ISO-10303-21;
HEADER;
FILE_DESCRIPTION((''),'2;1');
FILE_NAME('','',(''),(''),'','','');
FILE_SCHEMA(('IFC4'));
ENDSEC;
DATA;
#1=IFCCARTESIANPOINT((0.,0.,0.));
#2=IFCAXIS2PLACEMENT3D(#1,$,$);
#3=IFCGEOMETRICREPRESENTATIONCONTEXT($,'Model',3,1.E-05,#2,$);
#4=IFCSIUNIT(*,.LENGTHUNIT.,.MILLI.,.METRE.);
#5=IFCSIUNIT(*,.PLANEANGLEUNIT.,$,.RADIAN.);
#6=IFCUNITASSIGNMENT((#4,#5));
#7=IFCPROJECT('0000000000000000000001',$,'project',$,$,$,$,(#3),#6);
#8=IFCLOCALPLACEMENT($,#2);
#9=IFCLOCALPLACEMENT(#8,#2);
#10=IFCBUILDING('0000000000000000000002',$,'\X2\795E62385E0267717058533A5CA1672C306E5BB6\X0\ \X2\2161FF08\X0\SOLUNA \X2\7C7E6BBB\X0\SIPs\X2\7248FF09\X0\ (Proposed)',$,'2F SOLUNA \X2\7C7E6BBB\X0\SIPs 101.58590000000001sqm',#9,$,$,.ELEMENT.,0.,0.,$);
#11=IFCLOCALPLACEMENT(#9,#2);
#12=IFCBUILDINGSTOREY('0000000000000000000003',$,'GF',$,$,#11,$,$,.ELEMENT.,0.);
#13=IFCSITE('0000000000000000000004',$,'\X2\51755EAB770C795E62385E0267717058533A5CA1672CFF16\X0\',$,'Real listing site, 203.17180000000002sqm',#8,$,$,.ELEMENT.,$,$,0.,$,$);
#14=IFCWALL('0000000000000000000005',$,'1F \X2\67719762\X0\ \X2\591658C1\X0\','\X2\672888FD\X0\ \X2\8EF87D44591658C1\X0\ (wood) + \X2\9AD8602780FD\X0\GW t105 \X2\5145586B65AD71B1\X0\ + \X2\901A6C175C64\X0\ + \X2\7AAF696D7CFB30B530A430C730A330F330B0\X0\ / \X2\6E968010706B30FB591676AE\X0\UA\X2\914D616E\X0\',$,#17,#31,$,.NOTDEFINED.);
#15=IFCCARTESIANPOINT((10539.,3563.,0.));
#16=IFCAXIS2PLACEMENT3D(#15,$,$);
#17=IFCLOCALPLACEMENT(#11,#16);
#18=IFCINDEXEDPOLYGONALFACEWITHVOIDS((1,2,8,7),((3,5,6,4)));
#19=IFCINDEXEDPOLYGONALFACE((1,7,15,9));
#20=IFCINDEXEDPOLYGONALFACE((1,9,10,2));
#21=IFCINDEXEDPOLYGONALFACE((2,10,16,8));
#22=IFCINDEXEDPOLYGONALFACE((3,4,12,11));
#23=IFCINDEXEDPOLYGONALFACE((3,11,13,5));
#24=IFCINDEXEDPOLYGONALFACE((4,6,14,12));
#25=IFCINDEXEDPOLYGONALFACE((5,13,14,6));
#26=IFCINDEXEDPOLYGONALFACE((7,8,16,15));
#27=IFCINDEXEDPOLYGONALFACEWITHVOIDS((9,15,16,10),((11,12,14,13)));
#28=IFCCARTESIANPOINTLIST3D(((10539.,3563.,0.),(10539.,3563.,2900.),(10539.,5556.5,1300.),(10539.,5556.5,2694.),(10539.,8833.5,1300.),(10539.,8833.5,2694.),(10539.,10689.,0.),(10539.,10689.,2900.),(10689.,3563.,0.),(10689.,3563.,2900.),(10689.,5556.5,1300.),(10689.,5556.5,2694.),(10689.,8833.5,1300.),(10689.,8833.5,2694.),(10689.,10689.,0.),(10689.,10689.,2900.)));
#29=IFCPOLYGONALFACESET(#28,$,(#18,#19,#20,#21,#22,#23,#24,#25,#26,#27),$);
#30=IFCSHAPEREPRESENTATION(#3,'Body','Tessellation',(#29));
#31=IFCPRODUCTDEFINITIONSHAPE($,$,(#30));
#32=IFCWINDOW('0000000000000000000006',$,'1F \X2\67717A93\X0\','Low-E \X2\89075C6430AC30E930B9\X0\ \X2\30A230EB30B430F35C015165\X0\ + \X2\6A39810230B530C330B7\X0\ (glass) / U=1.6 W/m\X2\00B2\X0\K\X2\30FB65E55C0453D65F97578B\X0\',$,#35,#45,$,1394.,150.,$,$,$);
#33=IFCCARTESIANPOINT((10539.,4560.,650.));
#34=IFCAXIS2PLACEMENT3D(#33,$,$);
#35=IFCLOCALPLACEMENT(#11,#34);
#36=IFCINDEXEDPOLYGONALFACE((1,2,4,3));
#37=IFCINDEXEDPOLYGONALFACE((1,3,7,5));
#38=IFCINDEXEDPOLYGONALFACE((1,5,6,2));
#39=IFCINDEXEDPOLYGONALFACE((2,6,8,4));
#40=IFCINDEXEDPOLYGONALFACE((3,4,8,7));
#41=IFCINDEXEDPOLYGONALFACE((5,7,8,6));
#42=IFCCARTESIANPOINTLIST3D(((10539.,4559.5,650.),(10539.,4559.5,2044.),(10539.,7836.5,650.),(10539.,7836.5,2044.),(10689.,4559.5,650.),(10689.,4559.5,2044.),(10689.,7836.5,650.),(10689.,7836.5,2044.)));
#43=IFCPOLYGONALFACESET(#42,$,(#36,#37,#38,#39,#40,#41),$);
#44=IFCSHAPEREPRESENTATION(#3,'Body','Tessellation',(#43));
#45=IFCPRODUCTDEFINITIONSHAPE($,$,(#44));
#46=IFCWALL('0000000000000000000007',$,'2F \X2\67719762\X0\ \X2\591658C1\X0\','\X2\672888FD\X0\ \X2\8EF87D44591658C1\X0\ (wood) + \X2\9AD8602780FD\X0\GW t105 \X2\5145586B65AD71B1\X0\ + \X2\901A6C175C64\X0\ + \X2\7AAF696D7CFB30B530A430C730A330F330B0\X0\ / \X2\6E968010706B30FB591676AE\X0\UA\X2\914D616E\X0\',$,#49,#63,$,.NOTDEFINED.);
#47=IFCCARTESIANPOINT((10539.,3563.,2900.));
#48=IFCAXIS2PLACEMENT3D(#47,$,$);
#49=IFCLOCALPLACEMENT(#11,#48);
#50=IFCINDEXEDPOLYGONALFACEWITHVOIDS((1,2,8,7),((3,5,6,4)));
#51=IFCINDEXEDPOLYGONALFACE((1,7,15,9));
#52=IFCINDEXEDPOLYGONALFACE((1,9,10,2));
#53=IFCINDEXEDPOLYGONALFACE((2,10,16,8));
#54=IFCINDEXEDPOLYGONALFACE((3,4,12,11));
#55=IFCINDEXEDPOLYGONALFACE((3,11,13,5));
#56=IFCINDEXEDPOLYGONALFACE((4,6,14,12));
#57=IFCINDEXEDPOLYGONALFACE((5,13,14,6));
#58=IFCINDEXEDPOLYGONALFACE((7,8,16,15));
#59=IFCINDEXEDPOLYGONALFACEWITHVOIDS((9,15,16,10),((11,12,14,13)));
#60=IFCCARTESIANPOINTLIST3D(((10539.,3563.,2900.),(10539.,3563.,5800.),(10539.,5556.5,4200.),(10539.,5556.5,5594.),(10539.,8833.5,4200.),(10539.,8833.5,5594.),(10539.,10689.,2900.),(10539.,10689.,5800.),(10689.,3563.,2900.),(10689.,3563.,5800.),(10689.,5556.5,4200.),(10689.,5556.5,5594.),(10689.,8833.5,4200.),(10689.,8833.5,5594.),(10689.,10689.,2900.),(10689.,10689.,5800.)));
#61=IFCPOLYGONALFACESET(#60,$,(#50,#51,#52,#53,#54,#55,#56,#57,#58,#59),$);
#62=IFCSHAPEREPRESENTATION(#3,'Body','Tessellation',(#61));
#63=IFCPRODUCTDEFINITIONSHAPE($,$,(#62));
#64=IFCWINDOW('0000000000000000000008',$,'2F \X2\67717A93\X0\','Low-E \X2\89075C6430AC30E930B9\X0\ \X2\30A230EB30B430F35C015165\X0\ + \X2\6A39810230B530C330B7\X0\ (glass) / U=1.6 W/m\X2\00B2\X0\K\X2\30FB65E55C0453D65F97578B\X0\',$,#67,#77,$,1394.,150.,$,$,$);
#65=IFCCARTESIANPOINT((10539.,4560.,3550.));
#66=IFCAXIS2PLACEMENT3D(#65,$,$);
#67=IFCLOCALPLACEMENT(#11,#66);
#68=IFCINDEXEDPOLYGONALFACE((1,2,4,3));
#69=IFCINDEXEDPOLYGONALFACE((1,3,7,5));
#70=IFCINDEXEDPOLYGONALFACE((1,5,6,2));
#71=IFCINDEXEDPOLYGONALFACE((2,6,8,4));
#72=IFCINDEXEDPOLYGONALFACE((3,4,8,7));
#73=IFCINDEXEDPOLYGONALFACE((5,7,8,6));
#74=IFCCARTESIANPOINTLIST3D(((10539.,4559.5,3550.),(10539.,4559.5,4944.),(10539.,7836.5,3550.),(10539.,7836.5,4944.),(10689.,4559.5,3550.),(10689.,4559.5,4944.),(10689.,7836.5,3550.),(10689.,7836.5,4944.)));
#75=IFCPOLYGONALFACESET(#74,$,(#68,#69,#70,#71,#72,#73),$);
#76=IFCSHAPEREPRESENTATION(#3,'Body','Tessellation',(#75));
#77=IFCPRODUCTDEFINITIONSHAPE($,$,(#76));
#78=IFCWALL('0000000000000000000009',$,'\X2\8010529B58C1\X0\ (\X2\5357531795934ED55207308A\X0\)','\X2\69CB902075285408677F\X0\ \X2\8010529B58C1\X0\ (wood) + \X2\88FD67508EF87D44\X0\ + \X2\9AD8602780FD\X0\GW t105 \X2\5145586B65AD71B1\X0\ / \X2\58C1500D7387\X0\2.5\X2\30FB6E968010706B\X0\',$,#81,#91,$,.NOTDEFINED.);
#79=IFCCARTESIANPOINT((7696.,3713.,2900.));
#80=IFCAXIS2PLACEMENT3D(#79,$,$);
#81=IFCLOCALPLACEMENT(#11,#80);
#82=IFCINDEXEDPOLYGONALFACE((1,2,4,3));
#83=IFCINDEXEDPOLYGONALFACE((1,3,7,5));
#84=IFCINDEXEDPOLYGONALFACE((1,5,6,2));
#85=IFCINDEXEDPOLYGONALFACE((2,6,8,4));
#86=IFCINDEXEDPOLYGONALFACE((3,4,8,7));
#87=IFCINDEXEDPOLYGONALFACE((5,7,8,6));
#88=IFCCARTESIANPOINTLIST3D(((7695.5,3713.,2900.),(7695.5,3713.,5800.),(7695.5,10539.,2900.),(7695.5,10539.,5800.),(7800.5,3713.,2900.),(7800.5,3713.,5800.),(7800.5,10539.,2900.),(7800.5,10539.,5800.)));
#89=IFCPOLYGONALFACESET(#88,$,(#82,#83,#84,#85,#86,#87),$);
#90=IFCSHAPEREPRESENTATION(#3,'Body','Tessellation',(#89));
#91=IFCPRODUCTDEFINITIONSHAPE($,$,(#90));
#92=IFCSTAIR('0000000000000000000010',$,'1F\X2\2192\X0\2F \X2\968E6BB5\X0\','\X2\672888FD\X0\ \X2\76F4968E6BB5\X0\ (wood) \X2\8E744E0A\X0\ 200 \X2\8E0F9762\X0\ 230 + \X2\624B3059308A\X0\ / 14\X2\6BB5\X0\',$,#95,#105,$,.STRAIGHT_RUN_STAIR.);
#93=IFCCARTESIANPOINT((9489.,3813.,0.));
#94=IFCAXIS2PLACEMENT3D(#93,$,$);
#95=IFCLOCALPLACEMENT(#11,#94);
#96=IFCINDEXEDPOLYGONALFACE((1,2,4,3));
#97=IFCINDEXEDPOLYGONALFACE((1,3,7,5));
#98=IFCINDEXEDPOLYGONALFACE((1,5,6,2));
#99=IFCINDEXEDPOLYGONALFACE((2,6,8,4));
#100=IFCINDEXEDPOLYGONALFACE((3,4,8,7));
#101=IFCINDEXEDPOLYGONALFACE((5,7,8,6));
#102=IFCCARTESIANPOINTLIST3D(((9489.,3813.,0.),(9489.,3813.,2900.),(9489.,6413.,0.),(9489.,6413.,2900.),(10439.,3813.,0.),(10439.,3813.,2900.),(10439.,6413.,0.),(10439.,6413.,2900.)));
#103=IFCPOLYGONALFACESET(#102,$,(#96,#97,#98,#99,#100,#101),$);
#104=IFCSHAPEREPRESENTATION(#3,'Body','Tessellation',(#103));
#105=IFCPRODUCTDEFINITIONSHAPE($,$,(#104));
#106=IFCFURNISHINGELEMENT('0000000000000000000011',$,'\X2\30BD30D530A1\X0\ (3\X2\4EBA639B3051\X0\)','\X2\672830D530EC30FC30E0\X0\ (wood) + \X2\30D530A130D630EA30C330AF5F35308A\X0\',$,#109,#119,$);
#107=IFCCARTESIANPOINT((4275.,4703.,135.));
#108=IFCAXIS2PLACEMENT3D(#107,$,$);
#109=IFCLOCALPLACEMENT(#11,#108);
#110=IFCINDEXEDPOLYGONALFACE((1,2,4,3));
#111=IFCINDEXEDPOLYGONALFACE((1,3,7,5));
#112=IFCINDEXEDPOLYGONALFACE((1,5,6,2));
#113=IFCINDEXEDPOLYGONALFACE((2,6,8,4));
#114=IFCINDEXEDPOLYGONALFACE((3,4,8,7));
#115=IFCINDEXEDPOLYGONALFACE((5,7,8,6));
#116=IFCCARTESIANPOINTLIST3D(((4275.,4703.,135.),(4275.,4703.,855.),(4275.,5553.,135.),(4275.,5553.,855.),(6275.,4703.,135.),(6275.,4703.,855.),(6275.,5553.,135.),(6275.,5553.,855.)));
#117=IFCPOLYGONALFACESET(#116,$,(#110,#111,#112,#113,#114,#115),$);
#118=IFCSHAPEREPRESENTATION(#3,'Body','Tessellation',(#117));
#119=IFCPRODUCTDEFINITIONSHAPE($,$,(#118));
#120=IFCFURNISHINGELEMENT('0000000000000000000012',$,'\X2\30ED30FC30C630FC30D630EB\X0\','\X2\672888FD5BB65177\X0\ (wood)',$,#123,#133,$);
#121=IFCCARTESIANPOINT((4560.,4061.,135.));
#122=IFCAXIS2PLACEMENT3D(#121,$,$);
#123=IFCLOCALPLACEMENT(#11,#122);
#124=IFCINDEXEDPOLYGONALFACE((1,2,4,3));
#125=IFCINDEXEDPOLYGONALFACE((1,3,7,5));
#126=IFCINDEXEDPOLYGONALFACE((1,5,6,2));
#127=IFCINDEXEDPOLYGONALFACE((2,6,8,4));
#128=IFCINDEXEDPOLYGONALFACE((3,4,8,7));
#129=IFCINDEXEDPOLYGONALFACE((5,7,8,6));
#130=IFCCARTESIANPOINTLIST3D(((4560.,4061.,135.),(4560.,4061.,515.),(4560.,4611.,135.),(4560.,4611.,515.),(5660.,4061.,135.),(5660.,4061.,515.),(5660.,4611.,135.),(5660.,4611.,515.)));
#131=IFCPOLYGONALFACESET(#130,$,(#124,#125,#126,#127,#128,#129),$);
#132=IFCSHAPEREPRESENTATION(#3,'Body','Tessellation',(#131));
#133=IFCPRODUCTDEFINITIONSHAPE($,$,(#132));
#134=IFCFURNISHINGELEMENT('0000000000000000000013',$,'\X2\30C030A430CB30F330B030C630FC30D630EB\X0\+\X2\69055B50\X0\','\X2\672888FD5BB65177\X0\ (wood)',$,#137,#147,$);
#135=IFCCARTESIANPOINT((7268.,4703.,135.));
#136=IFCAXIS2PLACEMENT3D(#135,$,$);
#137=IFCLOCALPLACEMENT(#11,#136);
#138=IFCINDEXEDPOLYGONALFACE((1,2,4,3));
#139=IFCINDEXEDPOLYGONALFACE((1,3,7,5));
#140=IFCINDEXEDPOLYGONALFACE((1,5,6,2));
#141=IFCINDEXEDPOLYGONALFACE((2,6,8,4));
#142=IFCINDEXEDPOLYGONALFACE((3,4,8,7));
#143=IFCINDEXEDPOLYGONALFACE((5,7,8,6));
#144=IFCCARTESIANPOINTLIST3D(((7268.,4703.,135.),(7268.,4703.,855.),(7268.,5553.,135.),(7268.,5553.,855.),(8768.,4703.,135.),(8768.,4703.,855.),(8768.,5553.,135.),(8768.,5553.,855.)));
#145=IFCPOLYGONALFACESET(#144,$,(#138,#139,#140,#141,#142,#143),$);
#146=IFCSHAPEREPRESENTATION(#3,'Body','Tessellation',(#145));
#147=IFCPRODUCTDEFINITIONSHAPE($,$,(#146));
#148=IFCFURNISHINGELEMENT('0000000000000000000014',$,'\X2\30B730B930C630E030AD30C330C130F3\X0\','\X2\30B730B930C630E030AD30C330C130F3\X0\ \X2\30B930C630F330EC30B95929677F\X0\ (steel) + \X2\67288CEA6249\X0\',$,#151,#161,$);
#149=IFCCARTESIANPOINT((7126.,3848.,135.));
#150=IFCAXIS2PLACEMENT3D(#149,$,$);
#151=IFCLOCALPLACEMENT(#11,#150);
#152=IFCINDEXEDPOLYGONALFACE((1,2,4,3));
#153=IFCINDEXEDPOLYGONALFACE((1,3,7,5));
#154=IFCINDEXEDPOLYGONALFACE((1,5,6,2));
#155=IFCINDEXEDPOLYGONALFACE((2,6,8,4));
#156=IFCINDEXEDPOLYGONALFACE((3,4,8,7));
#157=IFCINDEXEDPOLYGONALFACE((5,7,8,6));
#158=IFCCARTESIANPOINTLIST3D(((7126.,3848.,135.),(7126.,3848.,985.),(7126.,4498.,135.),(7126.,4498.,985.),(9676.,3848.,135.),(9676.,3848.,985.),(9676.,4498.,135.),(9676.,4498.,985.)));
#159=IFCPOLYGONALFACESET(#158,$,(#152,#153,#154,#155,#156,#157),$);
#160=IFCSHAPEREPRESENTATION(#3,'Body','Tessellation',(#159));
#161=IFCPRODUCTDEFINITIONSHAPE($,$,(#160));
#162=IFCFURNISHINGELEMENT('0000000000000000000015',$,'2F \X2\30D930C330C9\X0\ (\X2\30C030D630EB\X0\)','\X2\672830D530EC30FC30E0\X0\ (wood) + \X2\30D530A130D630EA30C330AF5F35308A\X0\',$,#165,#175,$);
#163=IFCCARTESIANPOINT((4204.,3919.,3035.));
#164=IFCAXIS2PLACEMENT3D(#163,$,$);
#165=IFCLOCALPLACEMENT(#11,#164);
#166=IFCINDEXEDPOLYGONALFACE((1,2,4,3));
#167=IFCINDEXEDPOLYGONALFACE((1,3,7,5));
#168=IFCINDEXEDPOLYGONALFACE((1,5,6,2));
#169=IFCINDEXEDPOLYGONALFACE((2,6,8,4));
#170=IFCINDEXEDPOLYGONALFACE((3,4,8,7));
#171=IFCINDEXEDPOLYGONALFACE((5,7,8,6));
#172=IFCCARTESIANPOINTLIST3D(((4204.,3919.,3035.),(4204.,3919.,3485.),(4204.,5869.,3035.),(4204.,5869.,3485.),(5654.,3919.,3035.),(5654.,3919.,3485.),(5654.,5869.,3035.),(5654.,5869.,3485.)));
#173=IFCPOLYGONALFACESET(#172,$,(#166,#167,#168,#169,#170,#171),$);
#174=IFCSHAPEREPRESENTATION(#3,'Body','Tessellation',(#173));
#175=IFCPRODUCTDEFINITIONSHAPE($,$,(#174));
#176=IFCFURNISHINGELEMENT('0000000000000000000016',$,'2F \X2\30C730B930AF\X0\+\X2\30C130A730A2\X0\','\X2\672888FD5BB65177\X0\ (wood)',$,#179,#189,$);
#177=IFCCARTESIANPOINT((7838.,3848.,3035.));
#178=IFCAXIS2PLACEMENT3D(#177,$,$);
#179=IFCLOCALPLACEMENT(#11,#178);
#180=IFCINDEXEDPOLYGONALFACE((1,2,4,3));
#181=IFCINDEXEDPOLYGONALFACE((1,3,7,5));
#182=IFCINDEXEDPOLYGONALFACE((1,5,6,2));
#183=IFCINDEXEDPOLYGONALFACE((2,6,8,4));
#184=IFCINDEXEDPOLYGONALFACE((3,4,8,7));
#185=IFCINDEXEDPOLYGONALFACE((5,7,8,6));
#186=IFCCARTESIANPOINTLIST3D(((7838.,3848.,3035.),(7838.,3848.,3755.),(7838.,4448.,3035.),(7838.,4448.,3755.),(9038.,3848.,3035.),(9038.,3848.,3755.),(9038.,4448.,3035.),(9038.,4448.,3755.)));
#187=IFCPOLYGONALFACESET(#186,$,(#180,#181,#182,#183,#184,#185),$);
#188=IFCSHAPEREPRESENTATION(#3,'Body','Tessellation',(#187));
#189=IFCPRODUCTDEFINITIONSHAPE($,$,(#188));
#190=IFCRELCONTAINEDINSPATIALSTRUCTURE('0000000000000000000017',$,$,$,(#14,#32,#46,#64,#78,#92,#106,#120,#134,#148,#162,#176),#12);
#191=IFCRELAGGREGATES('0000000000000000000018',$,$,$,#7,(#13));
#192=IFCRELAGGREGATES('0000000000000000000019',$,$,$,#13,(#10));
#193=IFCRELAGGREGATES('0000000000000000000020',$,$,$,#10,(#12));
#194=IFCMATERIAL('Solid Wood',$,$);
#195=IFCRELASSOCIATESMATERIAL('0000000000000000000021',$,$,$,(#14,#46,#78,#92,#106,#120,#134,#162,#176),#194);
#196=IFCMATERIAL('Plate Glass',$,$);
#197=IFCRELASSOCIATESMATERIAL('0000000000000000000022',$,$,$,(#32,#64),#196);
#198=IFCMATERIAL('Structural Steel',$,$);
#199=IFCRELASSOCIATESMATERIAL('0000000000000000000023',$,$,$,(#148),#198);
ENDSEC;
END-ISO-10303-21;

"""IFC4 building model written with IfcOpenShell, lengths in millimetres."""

from ifc_helpers import new_model, si_unit, frame, frame_2d, origin, place, context, project, spatial, rectangle, extrude, material, element, fill, save


model = new_model("IFC4")

# Units and contexts
model_context = context("Model", 3, precision=1e-05, world=origin())
ifc_project = project(units=[si_unit("LENGTHUNIT", "METRE", prefix="MILLI"), si_unit("PLANEANGLEUNIT", "RADIAN")], contexts=[model_context])

# Site, building, storey
site_placement = place(None, origin())
site = spatial("IfcSite", under=ifc_project, at=site_placement, Name="兵庫県神戸市東灘区岡本６", ObjectType="Real listing site, 203.17180000000002sqm", CompositionType="ELEMENT", RefElevation=0.0)
building_placement = place(site_placement, origin())
building = spatial("IfcBuilding", under=site, at=building_placement, Name="神戸市東灘区岡本の家 Ⅱ（SOLUNA 籾殻SIPs版） (Proposed)", ObjectType="2F SOLUNA 籾殻SIPs 101.58590000000001sqm", CompositionType="ELEMENT", ElevationOfRefHeight=0.0, ElevationOfTerrain=0.0)
storey_placement = place(building_placement, origin())
storey = spatial("IfcBuildingStorey", under=building, at=storey_placement, Name="GF", CompositionType="ELEMENT", Elevation=0.0)

# Wall, opening, window
ifc_material_1 = material(Name="Solid Wood")
wall_1_placement = place(storey_placement, frame((10539.0, 3563.0, 0.0)))
wall_1 = element("IfcWall", 1, at=wall_1_placement, inside=storey, material=ifc_material_1, Name="1F 東面 外壁", Description="木製 軸組外壁 (wood) + 高性能GW t105 充填断熱 + 通気層 + 窯業系サイディング / 準耐火・外皮UA配慮", PredefinedType="NOTDEFINED", context=model_context, shape_type="SweptSolid", body=[
    extrude(rectangle(XDim=150.0, YDim=7126.0, at=frame_2d((75.0, 3563.0))), frame((10539.0, 3563.0, 0.0)), (0.0, 0.0, 1.0), 2900.0),
])
opening_1_placement = place(storey_placement, frame((10539.0, 4560.0, 650.0)))
opening_1 = element("IfcOpeningElement", 2, at=opening_1_placement, cuts=wall_1, PredefinedType="NOTDEFINED", context=model_context, shape_type="SweptSolid", body=[
    extrude(rectangle(XDim=150.0, YDim=3277.0, at=frame_2d((75.0, 1638.0))), frame((10539.0, 4560.0, 650.0)), (0.0, 0.0, 1.0), 1394.0),
])
ifc_material_2 = material(Name="Plate Glass")
window_1_placement = place(storey_placement, frame((10539.0, 4560.0, 650.0)))
window_1 = element("IfcWindow", 3, at=window_1_placement, inside=storey, material=ifc_material_2, Name="1F 東窓", Description="Low-E 複層ガラス アルゴン封入 + 樹脂サッシ (glass) / U=1.6 W/m²K・日射取得型", OverallHeight=1394.0, OverallWidth=150.0, context=model_context, shape_type="SweptSolid", body=[
    extrude(rectangle(XDim=150.0, YDim=3277.0, at=frame_2d((75.0, 1638.0))), frame((10539.0, 4560.0, 650.0)), (0.0, 0.0, 1.0), 1394.0),
])
fill(opening_1, window_1)

# Wall, opening, window
wall_2_placement = place(storey_placement, frame((10539.0, 3563.0, 2900.0)))
wall_2 = element("IfcWall", 4, at=wall_2_placement, inside=storey, material=ifc_material_1, Name="2F 東面 外壁", Description="木製 軸組外壁 (wood) + 高性能GW t105 充填断熱 + 通気層 + 窯業系サイディング / 準耐火・外皮UA配慮", PredefinedType="NOTDEFINED", context=model_context, shape_type="SweptSolid", body=[
    extrude(rectangle(XDim=150.0, YDim=7126.0, at=frame_2d((75.0, 3563.0))), frame((10539.0, 3563.0, 2900.0)), (0.0, 0.0, 1.0), 2900.0),
])
opening_2_placement = place(storey_placement, frame((10539.0, 4560.0, 3550.0)))
opening_2 = element("IfcOpeningElement", 5, at=opening_2_placement, cuts=wall_2, PredefinedType="NOTDEFINED", context=model_context, shape_type="SweptSolid", body=[
    extrude(rectangle(XDim=150.0, YDim=3277.0, at=frame_2d((75.0, 1638.0))), frame((10539.0, 4560.0, 3550.0)), (0.0, 0.0, 1.0), 1394.0),
])
window_2_placement = place(storey_placement, frame((10539.0, 4560.0, 3550.0)))
window_2 = element("IfcWindow", 6, at=window_2_placement, inside=storey, material=ifc_material_2, Name="2F 東窓", Description="Low-E 複層ガラス アルゴン封入 + 樹脂サッシ (glass) / U=1.6 W/m²K・日射取得型", OverallHeight=1394.0, OverallWidth=150.0, context=model_context, shape_type="SweptSolid", body=[
    extrude(rectangle(XDim=150.0, YDim=3277.0, at=frame_2d((75.0, 1638.0))), frame((10539.0, 4560.0, 3550.0)), (0.0, 0.0, 1.0), 1394.0),
])
fill(opening_2, window_2)

# Wall
wall_3_placement = place(storey_placement, frame((7696.0, 3713.0, 2900.0)))
element("IfcWall", 7, at=wall_3_placement, inside=storey, material=ifc_material_1, Name="耐力壁 (南北間仕切り)", Description="構造用合板 耐力壁 (wood) + 製材軸組 + 高性能GW t105 充填断熱 / 壁倍率2.5・準耐火", PredefinedType="NOTDEFINED", context=model_context, shape_type="SweptSolid", body=[
    extrude(rectangle(XDim=105.0, YDim=6826.0, at=frame_2d((52.0, 3413.0))), frame((7696.0, 3713.0, 2900.0)), (0.0, 0.0, 1.0), 2900.0),
])

# Stair
stair_placement = place(storey_placement, frame((9489.0, 3813.0, 0.0)))
element("IfcStair", 8, at=stair_placement, inside=storey, material=ifc_material_1, Name="1F→2F 階段", Description="木製 直階段 (wood) 蹴上 200 踏面 230 + 手すり / 14段", PredefinedType="STRAIGHT_RUN_STAIR", context=model_context, shape_type="SweptSolid", body=[
    extrude(rectangle(XDim=950.0, YDim=2600.0, at=frame_2d((475.0, 1300.0))), frame((9489.0, 3813.0, 0.0)), (0.0, 0.0, 1.0), 2900.0),
])

# Furnishing elements
furnishing_1_placement = place(storey_placement, frame((4275.0, 4703.0, 135.0)))
element("IfcFurnishingElement", 9, at=furnishing_1_placement, inside=storey, material=ifc_material_1, Name="ソファ (3人掛け)", Description="木フレーム (wood) + ファブリック張り", context=model_context, shape_type="SweptSolid", body=[
    extrude(rectangle(XDim=2000.0, YDim=850.0, at=frame_2d((1000.0, 425.0))), frame((4275.0, 4703.0, 135.0)), (0.0, 0.0, 1.0), 720.0),
])
furnishing_2_placement = place(storey_placement, frame((4560.0, 4061.0, 135.0)))
element("IfcFurnishingElement", 10, at=furnishing_2_placement, inside=storey, material=ifc_material_1, Name="ローテーブル", Description="木製家具 (wood)", context=model_context, shape_type="SweptSolid", body=[
    extrude(rectangle(XDim=1100.0, YDim=550.0, at=frame_2d((550.0, 275.0))), frame((4560.0, 4061.0, 135.0)), (0.0, 0.0, 1.0), 380.0),
])
furnishing_3_placement = place(storey_placement, frame((7268.0, 4703.0, 135.0)))
element("IfcFurnishingElement", 11, at=furnishing_3_placement, inside=storey, material=ifc_material_1, Name="ダイニングテーブル+椅子", Description="木製家具 (wood)", context=model_context, shape_type="SweptSolid", body=[
    extrude(rectangle(XDim=1500.0, YDim=850.0, at=frame_2d((750.0, 425.0))), frame((7268.0, 4703.0, 135.0)), (0.0, 0.0, 1.0), 720.0),
])
ifc_material_3 = material(Name="Structural Steel")
furnishing_4_placement = place(storey_placement, frame((7126.0, 3848.0, 135.0)))
element("IfcFurnishingElement", 12, at=furnishing_4_placement, inside=storey, material=ifc_material_3, Name="システムキッチン", Description="システムキッチン ステンレス天板 (steel) + 木質扉", context=model_context, shape_type="SweptSolid", body=[
    extrude(rectangle(XDim=2550.0, YDim=650.0, at=frame_2d((1275.0, 325.0))), frame((7126.0, 3848.0, 135.0)), (0.0, 0.0, 1.0), 850.0),
])
furnishing_5_placement = place(storey_placement, frame((4204.0, 3919.0, 3035.0)))
element("IfcFurnishingElement", 13, at=furnishing_5_placement, inside=storey, material=ifc_material_1, Name="2F ベッド (ダブル)", Description="木フレーム (wood) + ファブリック張り", context=model_context, shape_type="SweptSolid", body=[
    extrude(rectangle(XDim=1450.0, YDim=1950.0, at=frame_2d((725.0, 975.0))), frame((4204.0, 3919.0, 3035.0)), (0.0, 0.0, 1.0), 450.0),
])
furnishing_6_placement = place(storey_placement, frame((7838.0, 3848.0, 3035.0)))
element("IfcFurnishingElement", 14, at=furnishing_6_placement, inside=storey, material=ifc_material_1, Name="2F デスク+チェア", Description="木製家具 (wood)", context=model_context, shape_type="SweptSolid", body=[
    extrude(rectangle(XDim=1200.0, YDim=600.0, at=frame_2d((600.0, 300.0))), frame((7838.0, 3848.0, 3035.0)), (0.0, 0.0, 1.0), 720.0),
])

save(model, "model.ifc")
